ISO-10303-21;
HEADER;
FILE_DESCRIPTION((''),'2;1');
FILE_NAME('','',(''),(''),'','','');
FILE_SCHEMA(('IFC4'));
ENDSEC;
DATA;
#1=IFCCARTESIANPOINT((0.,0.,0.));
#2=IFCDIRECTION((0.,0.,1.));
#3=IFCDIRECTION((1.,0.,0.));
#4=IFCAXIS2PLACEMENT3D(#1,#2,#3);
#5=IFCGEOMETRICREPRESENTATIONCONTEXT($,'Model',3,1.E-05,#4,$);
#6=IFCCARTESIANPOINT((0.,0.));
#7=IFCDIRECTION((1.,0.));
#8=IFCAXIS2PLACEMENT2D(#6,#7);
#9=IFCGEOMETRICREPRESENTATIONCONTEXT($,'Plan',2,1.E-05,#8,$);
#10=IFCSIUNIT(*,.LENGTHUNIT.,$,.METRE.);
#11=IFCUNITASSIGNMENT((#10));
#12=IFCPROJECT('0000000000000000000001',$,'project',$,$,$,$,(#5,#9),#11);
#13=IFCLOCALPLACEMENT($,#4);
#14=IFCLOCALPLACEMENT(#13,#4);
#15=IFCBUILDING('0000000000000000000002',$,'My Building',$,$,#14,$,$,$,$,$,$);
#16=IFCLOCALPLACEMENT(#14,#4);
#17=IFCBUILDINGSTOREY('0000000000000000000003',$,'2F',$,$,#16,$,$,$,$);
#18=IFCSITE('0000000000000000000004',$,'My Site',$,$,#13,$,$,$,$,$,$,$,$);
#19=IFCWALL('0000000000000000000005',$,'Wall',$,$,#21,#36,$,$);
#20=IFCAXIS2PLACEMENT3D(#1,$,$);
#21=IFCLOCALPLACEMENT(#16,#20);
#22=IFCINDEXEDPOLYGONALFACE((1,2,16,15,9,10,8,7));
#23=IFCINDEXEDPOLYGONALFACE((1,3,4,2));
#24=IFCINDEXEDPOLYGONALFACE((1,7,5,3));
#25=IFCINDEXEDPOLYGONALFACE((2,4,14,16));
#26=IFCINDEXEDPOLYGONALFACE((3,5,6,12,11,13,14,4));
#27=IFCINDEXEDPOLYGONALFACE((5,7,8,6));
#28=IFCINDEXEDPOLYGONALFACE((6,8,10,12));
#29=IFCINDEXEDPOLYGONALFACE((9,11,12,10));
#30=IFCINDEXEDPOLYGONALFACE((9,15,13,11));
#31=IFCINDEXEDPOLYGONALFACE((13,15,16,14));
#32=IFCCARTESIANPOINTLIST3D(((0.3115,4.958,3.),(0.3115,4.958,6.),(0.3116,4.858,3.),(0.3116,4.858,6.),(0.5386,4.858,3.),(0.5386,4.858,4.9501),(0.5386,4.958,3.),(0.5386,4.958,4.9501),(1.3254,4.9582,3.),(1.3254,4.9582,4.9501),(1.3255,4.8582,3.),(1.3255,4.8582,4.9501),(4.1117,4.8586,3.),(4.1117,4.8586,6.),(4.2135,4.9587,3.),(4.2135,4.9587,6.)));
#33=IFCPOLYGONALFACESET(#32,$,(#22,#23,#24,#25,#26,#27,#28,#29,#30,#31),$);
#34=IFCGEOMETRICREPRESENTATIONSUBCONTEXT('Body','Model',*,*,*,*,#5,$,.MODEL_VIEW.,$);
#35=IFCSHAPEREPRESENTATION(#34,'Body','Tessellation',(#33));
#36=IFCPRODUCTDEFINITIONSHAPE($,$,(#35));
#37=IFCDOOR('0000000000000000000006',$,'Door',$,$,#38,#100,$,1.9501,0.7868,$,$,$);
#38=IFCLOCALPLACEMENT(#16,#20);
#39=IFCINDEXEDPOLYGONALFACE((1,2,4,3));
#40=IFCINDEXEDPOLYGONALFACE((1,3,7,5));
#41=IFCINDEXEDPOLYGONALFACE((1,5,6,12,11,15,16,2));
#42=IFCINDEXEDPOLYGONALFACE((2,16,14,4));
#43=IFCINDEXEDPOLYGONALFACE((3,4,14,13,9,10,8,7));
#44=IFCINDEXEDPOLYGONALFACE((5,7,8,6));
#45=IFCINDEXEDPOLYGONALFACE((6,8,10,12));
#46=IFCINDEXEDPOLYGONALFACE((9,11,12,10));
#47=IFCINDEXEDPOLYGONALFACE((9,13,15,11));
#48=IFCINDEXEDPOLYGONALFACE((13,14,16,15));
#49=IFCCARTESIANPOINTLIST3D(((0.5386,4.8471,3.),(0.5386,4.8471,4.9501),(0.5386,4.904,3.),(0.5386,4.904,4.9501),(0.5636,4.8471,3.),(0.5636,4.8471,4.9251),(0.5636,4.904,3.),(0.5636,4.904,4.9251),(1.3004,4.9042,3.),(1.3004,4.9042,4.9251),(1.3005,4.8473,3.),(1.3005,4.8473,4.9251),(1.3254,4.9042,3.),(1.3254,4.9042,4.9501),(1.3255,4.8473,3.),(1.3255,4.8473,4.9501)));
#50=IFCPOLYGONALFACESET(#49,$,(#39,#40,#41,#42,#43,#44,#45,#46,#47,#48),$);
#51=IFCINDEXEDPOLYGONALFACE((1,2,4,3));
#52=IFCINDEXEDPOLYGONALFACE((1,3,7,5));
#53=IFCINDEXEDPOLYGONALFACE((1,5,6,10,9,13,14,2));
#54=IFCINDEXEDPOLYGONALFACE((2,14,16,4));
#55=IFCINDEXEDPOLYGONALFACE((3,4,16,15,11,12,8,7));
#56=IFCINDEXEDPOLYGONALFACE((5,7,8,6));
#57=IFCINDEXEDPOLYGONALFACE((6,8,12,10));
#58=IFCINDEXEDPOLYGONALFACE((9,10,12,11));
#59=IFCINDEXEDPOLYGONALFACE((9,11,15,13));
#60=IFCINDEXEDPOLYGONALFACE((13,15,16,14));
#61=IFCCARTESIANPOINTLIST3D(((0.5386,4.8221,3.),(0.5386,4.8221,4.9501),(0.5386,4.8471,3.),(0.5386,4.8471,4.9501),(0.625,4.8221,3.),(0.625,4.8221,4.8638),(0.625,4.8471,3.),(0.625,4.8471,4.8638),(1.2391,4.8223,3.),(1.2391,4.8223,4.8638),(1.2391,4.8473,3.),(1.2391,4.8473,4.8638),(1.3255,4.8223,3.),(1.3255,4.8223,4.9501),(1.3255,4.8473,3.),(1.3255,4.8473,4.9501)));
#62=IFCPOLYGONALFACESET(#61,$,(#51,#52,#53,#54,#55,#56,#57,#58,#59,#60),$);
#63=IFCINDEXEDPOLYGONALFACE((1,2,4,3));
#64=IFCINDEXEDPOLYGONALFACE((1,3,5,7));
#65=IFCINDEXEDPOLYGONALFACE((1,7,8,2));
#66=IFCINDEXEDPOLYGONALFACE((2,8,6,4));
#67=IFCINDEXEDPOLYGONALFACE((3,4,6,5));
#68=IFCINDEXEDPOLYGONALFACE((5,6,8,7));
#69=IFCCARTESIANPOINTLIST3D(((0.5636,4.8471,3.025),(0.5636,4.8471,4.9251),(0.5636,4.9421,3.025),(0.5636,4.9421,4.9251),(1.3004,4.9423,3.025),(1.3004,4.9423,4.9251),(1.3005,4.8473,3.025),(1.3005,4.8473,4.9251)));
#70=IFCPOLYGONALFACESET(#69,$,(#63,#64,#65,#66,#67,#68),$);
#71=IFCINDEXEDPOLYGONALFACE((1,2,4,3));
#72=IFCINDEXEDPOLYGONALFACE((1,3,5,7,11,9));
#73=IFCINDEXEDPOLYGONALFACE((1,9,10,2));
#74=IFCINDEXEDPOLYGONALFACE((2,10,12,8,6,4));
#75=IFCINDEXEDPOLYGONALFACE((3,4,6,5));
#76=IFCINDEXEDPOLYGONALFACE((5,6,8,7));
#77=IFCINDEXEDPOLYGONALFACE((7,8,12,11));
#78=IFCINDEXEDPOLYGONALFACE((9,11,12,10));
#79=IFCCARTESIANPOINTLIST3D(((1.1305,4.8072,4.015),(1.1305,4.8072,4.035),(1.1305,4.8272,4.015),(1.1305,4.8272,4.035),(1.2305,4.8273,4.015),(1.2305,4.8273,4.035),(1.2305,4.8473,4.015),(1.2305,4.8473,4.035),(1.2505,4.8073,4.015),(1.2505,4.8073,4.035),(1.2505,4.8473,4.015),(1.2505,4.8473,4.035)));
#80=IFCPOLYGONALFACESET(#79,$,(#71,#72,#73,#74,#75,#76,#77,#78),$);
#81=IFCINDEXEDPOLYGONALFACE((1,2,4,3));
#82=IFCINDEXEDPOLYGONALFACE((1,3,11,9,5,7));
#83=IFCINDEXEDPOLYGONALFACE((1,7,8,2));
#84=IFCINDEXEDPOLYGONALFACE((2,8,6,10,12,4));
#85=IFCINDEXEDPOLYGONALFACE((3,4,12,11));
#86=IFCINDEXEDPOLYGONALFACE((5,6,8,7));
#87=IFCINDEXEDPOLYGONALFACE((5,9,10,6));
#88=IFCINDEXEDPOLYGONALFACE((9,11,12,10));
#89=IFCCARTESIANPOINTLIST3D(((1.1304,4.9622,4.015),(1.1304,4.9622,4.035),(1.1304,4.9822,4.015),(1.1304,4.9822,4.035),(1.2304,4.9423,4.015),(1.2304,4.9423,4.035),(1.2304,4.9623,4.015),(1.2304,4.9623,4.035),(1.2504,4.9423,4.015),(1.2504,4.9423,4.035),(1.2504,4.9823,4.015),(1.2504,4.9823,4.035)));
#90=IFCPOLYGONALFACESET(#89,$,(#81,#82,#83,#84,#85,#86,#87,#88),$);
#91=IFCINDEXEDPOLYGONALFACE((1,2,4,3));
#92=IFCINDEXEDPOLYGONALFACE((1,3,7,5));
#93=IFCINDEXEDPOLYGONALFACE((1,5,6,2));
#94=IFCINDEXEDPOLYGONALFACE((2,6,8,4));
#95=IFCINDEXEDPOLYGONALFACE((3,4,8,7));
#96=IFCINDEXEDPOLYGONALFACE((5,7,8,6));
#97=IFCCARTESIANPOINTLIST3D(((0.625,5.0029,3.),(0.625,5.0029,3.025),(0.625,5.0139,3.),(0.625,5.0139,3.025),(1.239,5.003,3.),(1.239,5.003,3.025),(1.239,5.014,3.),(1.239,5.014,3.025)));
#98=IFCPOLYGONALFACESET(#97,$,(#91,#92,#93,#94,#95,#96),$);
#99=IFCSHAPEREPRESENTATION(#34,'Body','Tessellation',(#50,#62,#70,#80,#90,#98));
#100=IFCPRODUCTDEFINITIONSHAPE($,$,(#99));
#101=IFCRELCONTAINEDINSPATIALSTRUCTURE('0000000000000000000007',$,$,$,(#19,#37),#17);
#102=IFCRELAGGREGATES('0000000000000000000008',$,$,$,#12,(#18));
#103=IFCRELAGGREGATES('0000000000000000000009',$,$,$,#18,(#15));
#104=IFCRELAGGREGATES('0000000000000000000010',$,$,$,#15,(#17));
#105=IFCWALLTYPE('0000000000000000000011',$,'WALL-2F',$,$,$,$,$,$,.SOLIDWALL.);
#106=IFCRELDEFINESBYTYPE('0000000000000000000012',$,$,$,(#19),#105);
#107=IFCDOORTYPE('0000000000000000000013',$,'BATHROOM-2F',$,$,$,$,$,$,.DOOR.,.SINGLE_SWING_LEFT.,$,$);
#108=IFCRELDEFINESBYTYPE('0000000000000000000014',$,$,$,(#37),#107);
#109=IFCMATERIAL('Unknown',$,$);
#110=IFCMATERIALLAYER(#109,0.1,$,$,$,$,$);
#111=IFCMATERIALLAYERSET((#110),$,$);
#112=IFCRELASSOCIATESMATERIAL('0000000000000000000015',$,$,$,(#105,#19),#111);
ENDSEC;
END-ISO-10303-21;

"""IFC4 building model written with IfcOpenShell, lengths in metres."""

from ifc_helpers import new_model, entity, si_unit, frame, origin_with_axes, origin_2d_with_axis, place, context, subcontext, project, spatial, line, indexed_curve, outline, extrude, shape, source, transform, mapped, material, layer, layer_set, layer_usage, type_object, type_shapes, element, fill, save


model = new_model("IFC4")

# Units and contexts
model_context = context("Model", 3, precision=1e-05, world=origin_with_axes())
plan_context = context("Plan", 2, precision=1e-05, world=origin_2d_with_axis())
body_context_1 = subcontext(model_context, "Body", "Model", "MODEL_VIEW")
body_context_2 = subcontext(plan_context, "Body", "Plan", "PLAN_VIEW")
ifc_project = project(units=[si_unit("LENGTHUNIT", "METRE")], contexts=[model_context, plan_context])

# Site, building, storey
site_placement = place(None, origin_with_axes())
site = spatial("IfcSite", under=ifc_project, at=site_placement, Name="My Site")
building_placement = place(site_placement, origin_with_axes())
building = spatial("IfcBuilding", under=site, at=building_placement, Name="My Building")
storey_placement = place(building_placement, origin_with_axes())
storey = spatial("IfcBuildingStorey", under=building, at=storey_placement, Name="2F")

# Shared definitions
ifc_material = material(Name="Unknown")

# Shared definitions
ifc_layer = layer(ifc_material, 0.1)
ifc_layer_set = layer_set([ifc_layer])
wall_type = type_object("IfcWallType", Name="WALL-2F", PredefinedType="SOLIDWALL", material=ifc_layer_set)

# Wall, opening, door
ifc_layer_usage_1 = layer_usage(ifc_layer_set, "AXIS2", "POSITIVE", 0.0)
wall_1_placement = place(storey_placement, frame((4.2135, 4.9587, 3.0), z_axis=(0.0, 0.0, 1.0), x_axis=(-1.0, -0.000176, 0.0)))
wall_1 = element("IfcWall", 1, at=wall_1_placement, inside=storey, type_object=wall_type, material=ifc_layer_usage_1, Name="Wall", context=body_context_1, shape_type="SweptSolid", body=[
    extrude(outline(indexed_curve([(0.0, 0.0), (0.1018, 0.1), (3.9019, 0.1), (3.9019, 0.0)], segments=[line(1, 2, 3, 4, 1)])), origin_with_axes(), (0.0, 0.0, 1.0), 3.0),
])
shared_shape_1 = source(origin_with_axes(), body_context_1, "Body", "SweptSolid", [
    extrude(outline(indexed_curve([(0.0, 0.0), (0.7868, 0.0), (0.7868, 1.9501), (0.0, 1.9501)], segments=[line(1, 2, 3, 4, 1)])), frame((0.0, -0.6, 0.0), z_axis=(0.0, -1.0, 0.0), x_axis=(1.0, 0.0, 0.0)), (0.0, 0.0, -1.0), 1.2),
])
opening_1_placement = place(wall_1_placement, frame((3.6749, 0.1, 0.0), z_axis=(0.0, 0.0, 1.0), x_axis=(-1.0, 0.0, 0.0)))
opening_1 = element("IfcOpeningElement", 2, at=opening_1_placement, cuts=wall_1, PredefinedType="OPENING", context=body_context_1, shape_type="MappedRepresentation", body=[
    mapped(shared_shape_1, transform((0.0, 0.0, 0.0), x_axis=(1.0, 0.0, 0.0), y_axis=(0.0, 1.0, 0.0), z_axis=(0.0, 0.0, 1.0), scale=1.0)),
])
door_type_1 = type_object("IfcDoorType", Name="BATHROOM-2F", OperationType="SINGLE_SWING_LEFT", PredefinedType="DOOR")
shared_shape_2 = source(origin_with_axes(), body_context_1, "Body", "SweptSolid", [
    extrude(outline(indexed_curve([(0.0, 0.0), (0.0, 1.9501), (0.7868, 1.9501), (0.7868, 0.0), (0.7618, 0.0), (0.7618, 1.9251), (0.025, 1.9251), (0.025, 0.0)], segments=[line(1, 2, 3, 4, 5, 6, 7, 8, 1)])), frame((0.0, 0.0093, 0.0), z_axis=(0.0, -1.0, 0.0), x_axis=(1.0, 0.0, 0.0)), (0.0, 0.0, -1.0), 0.0569),
    extrude(outline(indexed_curve([(0.0, 0.0), (0.0, 1.9501), (0.7868, 1.9501), (0.7868, 0.0), (0.7005, 0.0), (0.7005, 1.8638), (0.0864, 1.8638), (0.0864, 0.0)], segments=[line(1, 2, 3, 4, 5, 6, 7, 8, 1)])), frame((0.0, -0.0157, 0.0), z_axis=(0.0, -1.0, 0.0), x_axis=(1.0, 0.0, 0.0)), (0.0, 0.0, -1.0), 0.025),
    extrude(outline(indexed_curve([(0.0, 0.0), (0.7368, 0.0), (0.7368, 0.095), (0.0, 0.095)], segments=[line(1, 2, 3, 4, 1)])), frame((0.025, 0.0093, 0.025), z_axis=(0.0, 0.0, 1.0), x_axis=(1.0, 0.0, 0.0)), (0.0, 0.0, 1.0), 1.9001),
    extrude(outline(indexed_curve([(0.0, 0.0), (0.0, -0.04), (-0.12, -0.04), (-0.12, -0.02), (-0.02, -0.02), (-0.02, 0.0)], segments=[line(1, 2, 3, 4, 5, 6, 1)])), frame((0.7118, 0.0093, 1.015), z_axis=(0.0, 0.0, 1.0), x_axis=(1.0, 0.0, 0.0)), (0.0, 0.0, 1.0), 0.02),
    extrude(outline(indexed_curve([(0.0, 0.0), (0.0, 0.04), (-0.12, 0.04), (-0.12, 0.02), (-0.02, 0.02), (-0.02, 0.0)], segments=[line(1, 2, 3, 4, 5, 6, 1)])), frame((0.7118, 0.1043, 1.015), z_axis=(0.0, 0.0, 1.0), x_axis=(1.0, 0.0, 0.0)), (0.0, 0.0, 1.0), 0.02),
    extrude(outline(indexed_curve([(0.0, 0.0), (0.6141, 0.0), (0.6141, 0.011), (0.0, 0.011)], segments=[line(1, 2, 3, 4, 1)])), frame((0.0864, 0.165, 0.0), z_axis=(0.0, 0.0, 1.0), x_axis=(1.0, 0.0, 0.0)), (0.0, 0.0, 1.0), 0.025),
])
shared_shape_3 = source(origin_with_axes(), body_context_2, "Body", "Curve2D", [
    entity("IfcIndexedPolyCurve", entity("IfcCartesianPointList2D", [[0.0, -0.0157], [0.0, 0.0662], [0.025, 0.0662], [0.025, 0.0093], [0.0864, 0.0093], [0.0864, -0.0157]]), [entity("IfcLineIndex", [1, 2, 3, 4, 5, 6, 1])]),
    entity("IfcIndexedPolyCurve", entity("IfcCartesianPointList2D", [[0.7868, -0.0157], [0.7868, 0.0662], [0.7618, 0.0662], [0.7618, 0.0093], [0.7005, 0.0093], [0.7005, -0.0157]]), [entity("IfcLineIndex", [1, 2, 3, 4, 5, 6, 1])]),
    entity("IfcTrimmedCurve", entity("IfcEllipse", entity("IfcAxis2Placement2D", entity("IfcCartesianPoint", [0.12, 0.0662]), entity("IfcDirection", [1.0, 0.0])), 0.6418, 0.7368), [entity("IfcCartesianPoint", [0.7618, 0.0662])], [entity("IfcCartesianPoint", [0.12, 0.803])], True, "CARTESIAN"),
    entity("IfcIndexedPolyCurve", entity("IfcCartesianPointList2D", [[0.025, 0.0662], [0.12, 0.0662], [0.12, 0.803], [0.025, 0.803]]), [entity("IfcLineIndex", [1, 2, 3, 4, 1])]),
])
type_shapes(door_type_1, [shared_shape_2, shared_shape_3])
door_1_placement = place(opening_1_placement, frame((0.0, -0.0202, 0.0), z_axis=(0.0, 0.0, 1.0), x_axis=(1.0, 0.0, 0.0)))
door_1 = element("IfcDoor", 3, at=door_1_placement, inside=storey, type_object=door_type_1, Name="Door", OverallHeight=1.9501, OverallWidth=0.7868, shapes=[
    shape(body_context_1, "Body", "MappedRepresentation", [mapped(shared_shape_2, transform((0.0, 0.0, 0.0), x_axis=(1.0, 0.0, 0.0), y_axis=(0.0, 1.0, 0.0), z_axis=(0.0, 0.0, 1.0), scale=1.0))]),
    shape(body_context_2, "Body", "MappedRepresentation", [mapped(shared_shape_3, transform((0.0, 0.0, 0.0), x_axis=(1.0, 0.0, 0.0), y_axis=(0.0, 1.0, 0.0), z_axis=(0.0, 0.0, 1.0), scale=1.0))]),
])
fill(opening_1, door_1)

save(model, "model.ifc")
